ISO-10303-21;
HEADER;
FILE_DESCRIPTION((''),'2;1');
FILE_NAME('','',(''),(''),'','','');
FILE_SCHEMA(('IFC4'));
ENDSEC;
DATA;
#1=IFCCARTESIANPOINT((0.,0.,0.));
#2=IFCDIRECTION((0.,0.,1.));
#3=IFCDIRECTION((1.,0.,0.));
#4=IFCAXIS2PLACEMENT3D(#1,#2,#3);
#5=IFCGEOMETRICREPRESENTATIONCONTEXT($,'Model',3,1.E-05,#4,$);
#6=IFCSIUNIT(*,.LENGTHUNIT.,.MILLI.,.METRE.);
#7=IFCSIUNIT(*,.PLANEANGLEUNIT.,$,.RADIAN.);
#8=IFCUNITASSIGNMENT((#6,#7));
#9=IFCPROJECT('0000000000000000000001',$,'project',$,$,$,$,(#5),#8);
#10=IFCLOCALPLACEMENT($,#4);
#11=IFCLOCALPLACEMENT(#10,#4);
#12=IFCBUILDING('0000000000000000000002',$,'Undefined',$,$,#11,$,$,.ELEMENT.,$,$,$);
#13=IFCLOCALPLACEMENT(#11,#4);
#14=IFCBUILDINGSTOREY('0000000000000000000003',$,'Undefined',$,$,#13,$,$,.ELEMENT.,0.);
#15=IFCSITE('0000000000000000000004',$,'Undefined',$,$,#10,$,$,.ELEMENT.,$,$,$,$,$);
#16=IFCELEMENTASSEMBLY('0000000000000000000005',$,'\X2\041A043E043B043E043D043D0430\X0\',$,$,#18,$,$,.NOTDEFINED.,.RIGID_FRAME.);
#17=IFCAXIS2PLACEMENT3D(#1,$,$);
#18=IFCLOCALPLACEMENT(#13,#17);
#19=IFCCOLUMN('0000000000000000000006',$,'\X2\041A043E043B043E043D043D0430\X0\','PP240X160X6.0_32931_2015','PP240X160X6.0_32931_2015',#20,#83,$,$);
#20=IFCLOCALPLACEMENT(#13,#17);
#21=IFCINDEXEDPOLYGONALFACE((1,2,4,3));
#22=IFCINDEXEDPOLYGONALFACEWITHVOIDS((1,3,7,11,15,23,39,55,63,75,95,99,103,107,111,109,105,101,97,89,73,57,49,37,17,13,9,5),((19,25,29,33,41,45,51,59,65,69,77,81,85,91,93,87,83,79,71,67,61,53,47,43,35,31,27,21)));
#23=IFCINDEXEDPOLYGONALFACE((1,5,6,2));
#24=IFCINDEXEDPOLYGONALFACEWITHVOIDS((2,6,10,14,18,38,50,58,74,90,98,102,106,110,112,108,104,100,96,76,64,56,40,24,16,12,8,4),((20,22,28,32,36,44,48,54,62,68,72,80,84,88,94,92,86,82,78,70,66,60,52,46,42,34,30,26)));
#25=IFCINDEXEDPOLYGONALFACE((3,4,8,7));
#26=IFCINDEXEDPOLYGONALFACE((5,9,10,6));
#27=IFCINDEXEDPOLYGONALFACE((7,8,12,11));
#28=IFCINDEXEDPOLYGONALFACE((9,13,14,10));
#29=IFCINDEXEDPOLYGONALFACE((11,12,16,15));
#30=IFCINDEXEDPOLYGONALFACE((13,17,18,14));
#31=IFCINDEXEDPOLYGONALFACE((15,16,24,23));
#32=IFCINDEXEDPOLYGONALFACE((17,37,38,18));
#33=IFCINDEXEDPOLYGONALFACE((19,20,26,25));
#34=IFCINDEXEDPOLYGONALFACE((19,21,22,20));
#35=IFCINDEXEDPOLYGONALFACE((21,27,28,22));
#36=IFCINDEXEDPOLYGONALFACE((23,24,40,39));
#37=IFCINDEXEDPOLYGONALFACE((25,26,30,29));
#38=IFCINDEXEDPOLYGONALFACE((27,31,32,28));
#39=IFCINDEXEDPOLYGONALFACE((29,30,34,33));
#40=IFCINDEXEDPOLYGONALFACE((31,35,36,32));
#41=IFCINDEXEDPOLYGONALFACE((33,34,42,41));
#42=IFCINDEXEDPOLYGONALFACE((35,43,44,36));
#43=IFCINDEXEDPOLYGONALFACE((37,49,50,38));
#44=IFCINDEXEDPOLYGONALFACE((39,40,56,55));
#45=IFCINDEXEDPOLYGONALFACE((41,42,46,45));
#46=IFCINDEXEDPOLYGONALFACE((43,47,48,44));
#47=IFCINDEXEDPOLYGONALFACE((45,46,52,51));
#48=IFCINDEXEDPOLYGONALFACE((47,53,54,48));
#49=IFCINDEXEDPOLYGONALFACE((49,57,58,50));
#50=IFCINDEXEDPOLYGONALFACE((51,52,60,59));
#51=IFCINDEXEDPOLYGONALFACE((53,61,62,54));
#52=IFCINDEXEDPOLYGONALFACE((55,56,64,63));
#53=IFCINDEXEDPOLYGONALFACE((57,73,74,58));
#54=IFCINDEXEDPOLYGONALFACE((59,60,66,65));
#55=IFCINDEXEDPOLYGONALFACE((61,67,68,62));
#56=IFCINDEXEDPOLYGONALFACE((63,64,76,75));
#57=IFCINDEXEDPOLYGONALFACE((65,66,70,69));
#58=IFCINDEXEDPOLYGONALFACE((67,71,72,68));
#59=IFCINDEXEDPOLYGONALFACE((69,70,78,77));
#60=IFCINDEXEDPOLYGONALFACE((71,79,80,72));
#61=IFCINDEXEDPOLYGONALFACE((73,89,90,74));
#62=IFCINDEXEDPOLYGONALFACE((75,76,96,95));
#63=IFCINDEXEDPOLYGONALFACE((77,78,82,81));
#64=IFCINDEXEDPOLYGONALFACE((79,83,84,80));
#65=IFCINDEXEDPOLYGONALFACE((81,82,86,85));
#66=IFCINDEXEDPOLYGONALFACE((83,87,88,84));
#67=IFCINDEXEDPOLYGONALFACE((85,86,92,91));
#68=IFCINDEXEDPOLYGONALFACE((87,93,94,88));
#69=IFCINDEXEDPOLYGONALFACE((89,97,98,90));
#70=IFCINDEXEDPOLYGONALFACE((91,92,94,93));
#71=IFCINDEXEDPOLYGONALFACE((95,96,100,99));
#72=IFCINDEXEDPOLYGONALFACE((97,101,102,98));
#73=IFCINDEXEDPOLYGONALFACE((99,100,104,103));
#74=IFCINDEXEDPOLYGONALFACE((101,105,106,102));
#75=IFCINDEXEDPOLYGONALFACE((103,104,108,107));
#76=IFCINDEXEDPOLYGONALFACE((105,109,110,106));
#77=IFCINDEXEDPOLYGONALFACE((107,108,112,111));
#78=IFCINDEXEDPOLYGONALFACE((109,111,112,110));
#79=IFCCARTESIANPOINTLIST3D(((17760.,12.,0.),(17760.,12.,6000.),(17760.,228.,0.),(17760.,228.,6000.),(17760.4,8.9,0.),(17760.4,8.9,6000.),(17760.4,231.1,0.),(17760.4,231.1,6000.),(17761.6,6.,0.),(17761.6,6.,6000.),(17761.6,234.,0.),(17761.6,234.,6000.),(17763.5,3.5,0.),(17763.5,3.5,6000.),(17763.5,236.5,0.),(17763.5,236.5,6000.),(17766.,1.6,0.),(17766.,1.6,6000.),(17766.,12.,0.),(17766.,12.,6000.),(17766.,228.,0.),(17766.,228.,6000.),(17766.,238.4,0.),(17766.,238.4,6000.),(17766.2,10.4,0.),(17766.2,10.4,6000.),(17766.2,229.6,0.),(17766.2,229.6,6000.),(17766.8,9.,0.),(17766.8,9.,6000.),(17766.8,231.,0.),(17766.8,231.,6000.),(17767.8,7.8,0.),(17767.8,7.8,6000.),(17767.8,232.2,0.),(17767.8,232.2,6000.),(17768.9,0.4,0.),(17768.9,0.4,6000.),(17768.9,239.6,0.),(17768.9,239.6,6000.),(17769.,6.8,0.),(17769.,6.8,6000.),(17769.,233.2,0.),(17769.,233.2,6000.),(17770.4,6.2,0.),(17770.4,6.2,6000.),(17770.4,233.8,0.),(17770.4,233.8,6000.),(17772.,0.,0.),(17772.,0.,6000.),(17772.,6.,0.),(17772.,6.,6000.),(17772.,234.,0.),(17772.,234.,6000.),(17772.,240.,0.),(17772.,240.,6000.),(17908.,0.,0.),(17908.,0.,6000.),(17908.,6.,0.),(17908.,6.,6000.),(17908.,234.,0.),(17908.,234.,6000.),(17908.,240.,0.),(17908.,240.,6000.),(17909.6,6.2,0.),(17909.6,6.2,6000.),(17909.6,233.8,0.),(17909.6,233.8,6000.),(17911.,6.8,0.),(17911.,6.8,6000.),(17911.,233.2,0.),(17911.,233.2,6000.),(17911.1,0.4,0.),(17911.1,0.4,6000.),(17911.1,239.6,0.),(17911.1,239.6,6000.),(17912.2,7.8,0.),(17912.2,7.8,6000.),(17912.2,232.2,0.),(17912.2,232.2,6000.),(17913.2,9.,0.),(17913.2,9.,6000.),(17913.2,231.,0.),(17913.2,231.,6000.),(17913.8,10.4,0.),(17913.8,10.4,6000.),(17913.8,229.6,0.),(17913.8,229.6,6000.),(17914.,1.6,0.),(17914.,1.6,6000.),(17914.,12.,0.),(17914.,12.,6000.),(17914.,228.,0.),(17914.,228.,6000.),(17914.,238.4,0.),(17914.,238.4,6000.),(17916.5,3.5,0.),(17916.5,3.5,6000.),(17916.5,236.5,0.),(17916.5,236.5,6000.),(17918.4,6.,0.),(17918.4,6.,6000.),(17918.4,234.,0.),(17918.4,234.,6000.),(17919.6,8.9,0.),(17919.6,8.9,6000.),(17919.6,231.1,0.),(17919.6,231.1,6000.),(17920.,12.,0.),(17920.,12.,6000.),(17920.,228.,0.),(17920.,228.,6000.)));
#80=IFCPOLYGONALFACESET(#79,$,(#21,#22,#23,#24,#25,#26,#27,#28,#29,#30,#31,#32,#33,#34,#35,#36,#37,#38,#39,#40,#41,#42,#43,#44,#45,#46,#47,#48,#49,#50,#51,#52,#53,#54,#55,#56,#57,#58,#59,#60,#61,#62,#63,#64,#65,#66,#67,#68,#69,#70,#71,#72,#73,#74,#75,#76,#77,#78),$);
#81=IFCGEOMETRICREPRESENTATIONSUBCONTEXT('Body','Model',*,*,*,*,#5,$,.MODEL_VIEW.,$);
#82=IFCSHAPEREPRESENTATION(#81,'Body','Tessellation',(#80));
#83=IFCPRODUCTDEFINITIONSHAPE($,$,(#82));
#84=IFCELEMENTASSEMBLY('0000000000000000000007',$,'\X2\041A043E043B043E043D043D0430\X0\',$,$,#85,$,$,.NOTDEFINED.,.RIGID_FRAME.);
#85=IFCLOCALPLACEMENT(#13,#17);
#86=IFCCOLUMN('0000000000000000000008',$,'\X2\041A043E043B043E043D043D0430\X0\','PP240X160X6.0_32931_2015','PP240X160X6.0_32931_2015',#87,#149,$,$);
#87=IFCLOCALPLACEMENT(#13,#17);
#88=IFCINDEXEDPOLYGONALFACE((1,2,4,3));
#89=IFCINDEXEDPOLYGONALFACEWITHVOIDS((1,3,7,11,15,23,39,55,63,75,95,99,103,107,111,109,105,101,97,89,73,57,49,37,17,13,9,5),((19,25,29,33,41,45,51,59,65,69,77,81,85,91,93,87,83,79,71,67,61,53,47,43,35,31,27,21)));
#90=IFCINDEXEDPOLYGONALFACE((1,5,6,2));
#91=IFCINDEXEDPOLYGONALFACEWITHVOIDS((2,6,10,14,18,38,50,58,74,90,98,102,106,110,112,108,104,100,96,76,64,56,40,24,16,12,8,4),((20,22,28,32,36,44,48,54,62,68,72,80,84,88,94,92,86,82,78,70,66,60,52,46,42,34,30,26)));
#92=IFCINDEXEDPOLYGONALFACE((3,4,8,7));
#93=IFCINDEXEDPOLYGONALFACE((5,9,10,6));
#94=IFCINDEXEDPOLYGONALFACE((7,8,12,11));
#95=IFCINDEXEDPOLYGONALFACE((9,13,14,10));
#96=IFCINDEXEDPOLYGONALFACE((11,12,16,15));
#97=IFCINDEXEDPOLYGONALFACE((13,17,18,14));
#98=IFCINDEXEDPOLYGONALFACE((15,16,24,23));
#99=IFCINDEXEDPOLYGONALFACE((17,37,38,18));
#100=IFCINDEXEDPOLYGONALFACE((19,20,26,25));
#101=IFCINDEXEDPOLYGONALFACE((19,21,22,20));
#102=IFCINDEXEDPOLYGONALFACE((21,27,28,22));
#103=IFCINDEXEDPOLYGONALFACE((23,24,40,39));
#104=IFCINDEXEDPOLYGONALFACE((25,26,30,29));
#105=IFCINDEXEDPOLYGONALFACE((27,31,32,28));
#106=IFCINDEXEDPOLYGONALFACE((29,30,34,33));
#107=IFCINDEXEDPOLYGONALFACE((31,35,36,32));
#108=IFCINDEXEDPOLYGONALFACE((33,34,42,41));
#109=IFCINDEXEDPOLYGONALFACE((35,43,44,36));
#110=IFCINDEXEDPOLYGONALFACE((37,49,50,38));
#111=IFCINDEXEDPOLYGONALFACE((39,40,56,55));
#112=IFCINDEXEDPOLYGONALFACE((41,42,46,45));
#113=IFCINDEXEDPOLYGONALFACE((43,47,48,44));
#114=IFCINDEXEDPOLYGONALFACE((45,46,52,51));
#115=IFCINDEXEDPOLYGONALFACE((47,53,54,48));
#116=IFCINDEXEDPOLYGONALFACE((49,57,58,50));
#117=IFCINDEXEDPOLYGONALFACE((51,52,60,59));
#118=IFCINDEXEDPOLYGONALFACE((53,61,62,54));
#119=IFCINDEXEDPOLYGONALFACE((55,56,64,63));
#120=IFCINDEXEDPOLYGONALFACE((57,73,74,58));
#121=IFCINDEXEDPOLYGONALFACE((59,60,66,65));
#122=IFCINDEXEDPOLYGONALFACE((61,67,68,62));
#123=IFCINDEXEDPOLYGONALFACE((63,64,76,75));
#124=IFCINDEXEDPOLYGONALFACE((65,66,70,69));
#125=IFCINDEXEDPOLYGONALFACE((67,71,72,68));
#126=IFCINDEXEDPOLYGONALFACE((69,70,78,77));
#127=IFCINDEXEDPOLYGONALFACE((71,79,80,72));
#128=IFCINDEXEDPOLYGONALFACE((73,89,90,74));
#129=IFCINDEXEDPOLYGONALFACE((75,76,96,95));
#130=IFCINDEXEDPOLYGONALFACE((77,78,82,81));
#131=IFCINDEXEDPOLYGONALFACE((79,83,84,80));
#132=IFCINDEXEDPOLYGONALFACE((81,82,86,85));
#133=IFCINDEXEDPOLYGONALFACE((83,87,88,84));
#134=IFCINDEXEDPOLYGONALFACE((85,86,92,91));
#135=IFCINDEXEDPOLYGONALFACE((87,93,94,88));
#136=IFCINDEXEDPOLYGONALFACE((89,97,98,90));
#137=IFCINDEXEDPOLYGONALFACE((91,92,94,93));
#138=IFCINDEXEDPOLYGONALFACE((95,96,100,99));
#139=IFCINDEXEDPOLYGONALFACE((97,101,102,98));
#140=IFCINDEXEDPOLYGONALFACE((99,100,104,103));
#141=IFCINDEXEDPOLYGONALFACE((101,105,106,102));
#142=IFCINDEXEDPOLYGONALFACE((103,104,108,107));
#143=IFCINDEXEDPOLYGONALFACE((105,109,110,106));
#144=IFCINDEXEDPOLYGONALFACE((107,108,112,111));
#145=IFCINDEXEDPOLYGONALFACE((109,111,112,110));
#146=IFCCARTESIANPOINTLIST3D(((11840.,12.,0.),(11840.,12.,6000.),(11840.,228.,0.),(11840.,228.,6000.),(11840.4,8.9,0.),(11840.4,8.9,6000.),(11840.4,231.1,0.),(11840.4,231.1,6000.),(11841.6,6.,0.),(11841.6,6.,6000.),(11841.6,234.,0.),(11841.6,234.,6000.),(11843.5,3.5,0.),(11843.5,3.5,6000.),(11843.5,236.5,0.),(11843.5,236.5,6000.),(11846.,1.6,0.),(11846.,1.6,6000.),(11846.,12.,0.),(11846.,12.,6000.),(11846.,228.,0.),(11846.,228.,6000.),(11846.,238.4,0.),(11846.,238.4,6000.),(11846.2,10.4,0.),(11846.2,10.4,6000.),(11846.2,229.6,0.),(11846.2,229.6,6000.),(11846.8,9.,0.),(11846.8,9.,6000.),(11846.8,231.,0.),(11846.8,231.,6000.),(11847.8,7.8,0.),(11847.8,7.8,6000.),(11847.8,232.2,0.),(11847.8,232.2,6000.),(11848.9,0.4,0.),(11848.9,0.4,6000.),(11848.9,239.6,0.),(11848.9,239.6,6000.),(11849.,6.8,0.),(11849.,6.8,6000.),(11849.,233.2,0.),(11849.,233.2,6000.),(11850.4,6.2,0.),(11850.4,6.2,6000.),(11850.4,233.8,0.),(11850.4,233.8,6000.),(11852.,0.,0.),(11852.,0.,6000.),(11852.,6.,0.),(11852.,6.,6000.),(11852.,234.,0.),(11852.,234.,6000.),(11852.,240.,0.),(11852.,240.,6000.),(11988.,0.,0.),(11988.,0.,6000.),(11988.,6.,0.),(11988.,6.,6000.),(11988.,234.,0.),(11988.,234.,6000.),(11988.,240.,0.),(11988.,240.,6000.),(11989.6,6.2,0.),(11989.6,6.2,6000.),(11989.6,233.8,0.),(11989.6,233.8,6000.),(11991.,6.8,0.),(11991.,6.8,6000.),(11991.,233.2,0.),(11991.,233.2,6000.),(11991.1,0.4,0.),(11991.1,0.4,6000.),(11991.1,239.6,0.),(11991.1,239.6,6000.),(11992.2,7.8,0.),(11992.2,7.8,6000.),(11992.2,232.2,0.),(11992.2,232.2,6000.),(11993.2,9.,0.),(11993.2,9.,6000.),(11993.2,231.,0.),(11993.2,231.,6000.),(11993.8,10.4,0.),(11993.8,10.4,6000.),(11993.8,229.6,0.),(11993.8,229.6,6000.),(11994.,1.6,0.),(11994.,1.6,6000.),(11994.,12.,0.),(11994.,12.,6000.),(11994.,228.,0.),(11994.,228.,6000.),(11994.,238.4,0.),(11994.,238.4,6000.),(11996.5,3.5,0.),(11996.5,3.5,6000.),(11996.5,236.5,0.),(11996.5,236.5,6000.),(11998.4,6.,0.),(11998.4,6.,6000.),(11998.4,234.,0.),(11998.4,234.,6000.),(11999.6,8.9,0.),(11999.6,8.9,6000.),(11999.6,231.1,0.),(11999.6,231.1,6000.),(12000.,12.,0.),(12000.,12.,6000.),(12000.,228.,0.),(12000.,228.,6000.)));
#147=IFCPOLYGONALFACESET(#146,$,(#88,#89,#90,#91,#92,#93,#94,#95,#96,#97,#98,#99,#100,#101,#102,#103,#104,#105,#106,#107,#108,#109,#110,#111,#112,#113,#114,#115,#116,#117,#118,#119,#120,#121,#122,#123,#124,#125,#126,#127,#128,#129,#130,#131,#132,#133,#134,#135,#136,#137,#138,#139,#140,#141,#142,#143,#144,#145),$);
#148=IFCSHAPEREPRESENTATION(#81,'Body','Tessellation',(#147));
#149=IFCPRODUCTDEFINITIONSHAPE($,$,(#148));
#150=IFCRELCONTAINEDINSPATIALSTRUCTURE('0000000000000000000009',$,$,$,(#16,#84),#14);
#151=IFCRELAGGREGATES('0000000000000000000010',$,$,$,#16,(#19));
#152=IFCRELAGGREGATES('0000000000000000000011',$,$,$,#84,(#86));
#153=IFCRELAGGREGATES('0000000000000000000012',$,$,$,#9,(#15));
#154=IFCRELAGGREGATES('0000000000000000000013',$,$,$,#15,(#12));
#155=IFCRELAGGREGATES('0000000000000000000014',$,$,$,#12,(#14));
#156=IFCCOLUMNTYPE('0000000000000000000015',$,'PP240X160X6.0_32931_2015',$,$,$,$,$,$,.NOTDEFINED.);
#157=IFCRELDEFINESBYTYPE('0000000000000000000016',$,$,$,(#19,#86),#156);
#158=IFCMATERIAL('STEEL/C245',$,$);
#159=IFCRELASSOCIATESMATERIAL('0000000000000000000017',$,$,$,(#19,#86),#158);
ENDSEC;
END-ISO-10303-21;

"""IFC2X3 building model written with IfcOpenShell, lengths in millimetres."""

from ifc_helpers import new_model, si_unit, frame, origin_with_axes, origin_2d_with_axis, place, context, subcontext, project, spatial, hollow_rectangle, extrude, material, type_object, element, aggregate, save


model = new_model("IFC2X3")

# Units and contexts
model_context = context("Model", 3, precision=1e-05, world=origin_with_axes())
body_context = subcontext(model_context, "Body", "Model", "MODEL_VIEW")
ifc_project = project(units=[si_unit("LENGTHUNIT", "METRE", prefix="MILLI"), si_unit("PLANEANGLEUNIT", "RADIAN")], contexts=[model_context])

# Site, building, storey
site_placement = place(None, origin_with_axes())
site = spatial("IfcSite", under=ifc_project, at=site_placement, Name="Undefined", CompositionType="ELEMENT")
building_placement = place(site_placement, origin_with_axes())
building = spatial("IfcBuilding", under=site, at=building_placement, Name="Undefined", CompositionType="ELEMENT")
storey_placement = place(building_placement, origin_with_axes())
storey = spatial("IfcBuildingStorey", under=building, at=storey_placement, Name="Undefined", CompositionType="ELEMENT", Elevation=0.0)

# Element assemblies, columns
assembly_1_placement = place(storey_placement, origin_with_axes())
assembly_1 = element("IfcElementAssembly", 1, at=assembly_1_placement, inside=storey, Name="Колонна", AssemblyPlace="NOTDEFINED", PredefinedType="RIGID_FRAME")
ifc_material = material(Name="STEEL/C245")
column_type = type_object("IfcColumnType", Name="PP240X160X6.0_32931_2015", PredefinedType="NOTDEFINED")
column_1_placement = place(assembly_1_placement, frame((17840.0, 120.0, 0.0), z_axis=(0.0, 0.0, 1.0), x_axis=(0.0, 1.0, 0.0)))
column_1 = element("IfcColumn", 2, at=column_1_placement, type_object=column_type, material=ifc_material, Name="Колонна", Description="PP240X160X6.0_32931_2015", ObjectType="PP240X160X6.0_32931_2015", context=body_context, shape_type="SweptSolid", body=[
    extrude(hollow_rectangle(XDim=160.0, YDim=240.0, WallThickness=6.0, InnerFilletRadius=6.0, OuterFilletRadius=12.0, at=origin_2d_with_axis()), frame((0.0, 0.0, 6000.0), z_axis=(0.0, 0.0, -1.0), x_axis=(0.0, 1.0, 0.0)), (0.0, 0.0, 1.0), 6000.0),
])
aggregate(assembly_1, [column_1])
assembly_2_placement = place(storey_placement, origin_with_axes())
assembly_2 = element("IfcElementAssembly", 3, at=assembly_2_placement, inside=storey, Name="Колонна", AssemblyPlace="NOTDEFINED", PredefinedType="RIGID_FRAME")
column_2_placement = place(assembly_2_placement, frame((11920.0, 120.0, 0.0), z_axis=(0.0, 0.0, 1.0), x_axis=(0.0, 1.0, 0.0)))
column_2 = element("IfcColumn", 4, at=column_2_placement, type_object=column_type, material=ifc_material, Name="Колонна", Description="PP240X160X6.0_32931_2015", ObjectType="PP240X160X6.0_32931_2015", context=body_context, shape_type="SweptSolid", body=[
    extrude(hollow_rectangle(XDim=160.0, YDim=240.0, WallThickness=6.0, InnerFilletRadius=6.0, OuterFilletRadius=12.0, at=origin_2d_with_axis()), frame((0.0, 0.0, 6000.0), z_axis=(0.0, 0.0, -1.0), x_axis=(0.0, 1.0, 0.0)), (0.0, 0.0, 1.0), 6000.0),
])
aggregate(assembly_2, [column_2])

save(model, "model.ifc")
